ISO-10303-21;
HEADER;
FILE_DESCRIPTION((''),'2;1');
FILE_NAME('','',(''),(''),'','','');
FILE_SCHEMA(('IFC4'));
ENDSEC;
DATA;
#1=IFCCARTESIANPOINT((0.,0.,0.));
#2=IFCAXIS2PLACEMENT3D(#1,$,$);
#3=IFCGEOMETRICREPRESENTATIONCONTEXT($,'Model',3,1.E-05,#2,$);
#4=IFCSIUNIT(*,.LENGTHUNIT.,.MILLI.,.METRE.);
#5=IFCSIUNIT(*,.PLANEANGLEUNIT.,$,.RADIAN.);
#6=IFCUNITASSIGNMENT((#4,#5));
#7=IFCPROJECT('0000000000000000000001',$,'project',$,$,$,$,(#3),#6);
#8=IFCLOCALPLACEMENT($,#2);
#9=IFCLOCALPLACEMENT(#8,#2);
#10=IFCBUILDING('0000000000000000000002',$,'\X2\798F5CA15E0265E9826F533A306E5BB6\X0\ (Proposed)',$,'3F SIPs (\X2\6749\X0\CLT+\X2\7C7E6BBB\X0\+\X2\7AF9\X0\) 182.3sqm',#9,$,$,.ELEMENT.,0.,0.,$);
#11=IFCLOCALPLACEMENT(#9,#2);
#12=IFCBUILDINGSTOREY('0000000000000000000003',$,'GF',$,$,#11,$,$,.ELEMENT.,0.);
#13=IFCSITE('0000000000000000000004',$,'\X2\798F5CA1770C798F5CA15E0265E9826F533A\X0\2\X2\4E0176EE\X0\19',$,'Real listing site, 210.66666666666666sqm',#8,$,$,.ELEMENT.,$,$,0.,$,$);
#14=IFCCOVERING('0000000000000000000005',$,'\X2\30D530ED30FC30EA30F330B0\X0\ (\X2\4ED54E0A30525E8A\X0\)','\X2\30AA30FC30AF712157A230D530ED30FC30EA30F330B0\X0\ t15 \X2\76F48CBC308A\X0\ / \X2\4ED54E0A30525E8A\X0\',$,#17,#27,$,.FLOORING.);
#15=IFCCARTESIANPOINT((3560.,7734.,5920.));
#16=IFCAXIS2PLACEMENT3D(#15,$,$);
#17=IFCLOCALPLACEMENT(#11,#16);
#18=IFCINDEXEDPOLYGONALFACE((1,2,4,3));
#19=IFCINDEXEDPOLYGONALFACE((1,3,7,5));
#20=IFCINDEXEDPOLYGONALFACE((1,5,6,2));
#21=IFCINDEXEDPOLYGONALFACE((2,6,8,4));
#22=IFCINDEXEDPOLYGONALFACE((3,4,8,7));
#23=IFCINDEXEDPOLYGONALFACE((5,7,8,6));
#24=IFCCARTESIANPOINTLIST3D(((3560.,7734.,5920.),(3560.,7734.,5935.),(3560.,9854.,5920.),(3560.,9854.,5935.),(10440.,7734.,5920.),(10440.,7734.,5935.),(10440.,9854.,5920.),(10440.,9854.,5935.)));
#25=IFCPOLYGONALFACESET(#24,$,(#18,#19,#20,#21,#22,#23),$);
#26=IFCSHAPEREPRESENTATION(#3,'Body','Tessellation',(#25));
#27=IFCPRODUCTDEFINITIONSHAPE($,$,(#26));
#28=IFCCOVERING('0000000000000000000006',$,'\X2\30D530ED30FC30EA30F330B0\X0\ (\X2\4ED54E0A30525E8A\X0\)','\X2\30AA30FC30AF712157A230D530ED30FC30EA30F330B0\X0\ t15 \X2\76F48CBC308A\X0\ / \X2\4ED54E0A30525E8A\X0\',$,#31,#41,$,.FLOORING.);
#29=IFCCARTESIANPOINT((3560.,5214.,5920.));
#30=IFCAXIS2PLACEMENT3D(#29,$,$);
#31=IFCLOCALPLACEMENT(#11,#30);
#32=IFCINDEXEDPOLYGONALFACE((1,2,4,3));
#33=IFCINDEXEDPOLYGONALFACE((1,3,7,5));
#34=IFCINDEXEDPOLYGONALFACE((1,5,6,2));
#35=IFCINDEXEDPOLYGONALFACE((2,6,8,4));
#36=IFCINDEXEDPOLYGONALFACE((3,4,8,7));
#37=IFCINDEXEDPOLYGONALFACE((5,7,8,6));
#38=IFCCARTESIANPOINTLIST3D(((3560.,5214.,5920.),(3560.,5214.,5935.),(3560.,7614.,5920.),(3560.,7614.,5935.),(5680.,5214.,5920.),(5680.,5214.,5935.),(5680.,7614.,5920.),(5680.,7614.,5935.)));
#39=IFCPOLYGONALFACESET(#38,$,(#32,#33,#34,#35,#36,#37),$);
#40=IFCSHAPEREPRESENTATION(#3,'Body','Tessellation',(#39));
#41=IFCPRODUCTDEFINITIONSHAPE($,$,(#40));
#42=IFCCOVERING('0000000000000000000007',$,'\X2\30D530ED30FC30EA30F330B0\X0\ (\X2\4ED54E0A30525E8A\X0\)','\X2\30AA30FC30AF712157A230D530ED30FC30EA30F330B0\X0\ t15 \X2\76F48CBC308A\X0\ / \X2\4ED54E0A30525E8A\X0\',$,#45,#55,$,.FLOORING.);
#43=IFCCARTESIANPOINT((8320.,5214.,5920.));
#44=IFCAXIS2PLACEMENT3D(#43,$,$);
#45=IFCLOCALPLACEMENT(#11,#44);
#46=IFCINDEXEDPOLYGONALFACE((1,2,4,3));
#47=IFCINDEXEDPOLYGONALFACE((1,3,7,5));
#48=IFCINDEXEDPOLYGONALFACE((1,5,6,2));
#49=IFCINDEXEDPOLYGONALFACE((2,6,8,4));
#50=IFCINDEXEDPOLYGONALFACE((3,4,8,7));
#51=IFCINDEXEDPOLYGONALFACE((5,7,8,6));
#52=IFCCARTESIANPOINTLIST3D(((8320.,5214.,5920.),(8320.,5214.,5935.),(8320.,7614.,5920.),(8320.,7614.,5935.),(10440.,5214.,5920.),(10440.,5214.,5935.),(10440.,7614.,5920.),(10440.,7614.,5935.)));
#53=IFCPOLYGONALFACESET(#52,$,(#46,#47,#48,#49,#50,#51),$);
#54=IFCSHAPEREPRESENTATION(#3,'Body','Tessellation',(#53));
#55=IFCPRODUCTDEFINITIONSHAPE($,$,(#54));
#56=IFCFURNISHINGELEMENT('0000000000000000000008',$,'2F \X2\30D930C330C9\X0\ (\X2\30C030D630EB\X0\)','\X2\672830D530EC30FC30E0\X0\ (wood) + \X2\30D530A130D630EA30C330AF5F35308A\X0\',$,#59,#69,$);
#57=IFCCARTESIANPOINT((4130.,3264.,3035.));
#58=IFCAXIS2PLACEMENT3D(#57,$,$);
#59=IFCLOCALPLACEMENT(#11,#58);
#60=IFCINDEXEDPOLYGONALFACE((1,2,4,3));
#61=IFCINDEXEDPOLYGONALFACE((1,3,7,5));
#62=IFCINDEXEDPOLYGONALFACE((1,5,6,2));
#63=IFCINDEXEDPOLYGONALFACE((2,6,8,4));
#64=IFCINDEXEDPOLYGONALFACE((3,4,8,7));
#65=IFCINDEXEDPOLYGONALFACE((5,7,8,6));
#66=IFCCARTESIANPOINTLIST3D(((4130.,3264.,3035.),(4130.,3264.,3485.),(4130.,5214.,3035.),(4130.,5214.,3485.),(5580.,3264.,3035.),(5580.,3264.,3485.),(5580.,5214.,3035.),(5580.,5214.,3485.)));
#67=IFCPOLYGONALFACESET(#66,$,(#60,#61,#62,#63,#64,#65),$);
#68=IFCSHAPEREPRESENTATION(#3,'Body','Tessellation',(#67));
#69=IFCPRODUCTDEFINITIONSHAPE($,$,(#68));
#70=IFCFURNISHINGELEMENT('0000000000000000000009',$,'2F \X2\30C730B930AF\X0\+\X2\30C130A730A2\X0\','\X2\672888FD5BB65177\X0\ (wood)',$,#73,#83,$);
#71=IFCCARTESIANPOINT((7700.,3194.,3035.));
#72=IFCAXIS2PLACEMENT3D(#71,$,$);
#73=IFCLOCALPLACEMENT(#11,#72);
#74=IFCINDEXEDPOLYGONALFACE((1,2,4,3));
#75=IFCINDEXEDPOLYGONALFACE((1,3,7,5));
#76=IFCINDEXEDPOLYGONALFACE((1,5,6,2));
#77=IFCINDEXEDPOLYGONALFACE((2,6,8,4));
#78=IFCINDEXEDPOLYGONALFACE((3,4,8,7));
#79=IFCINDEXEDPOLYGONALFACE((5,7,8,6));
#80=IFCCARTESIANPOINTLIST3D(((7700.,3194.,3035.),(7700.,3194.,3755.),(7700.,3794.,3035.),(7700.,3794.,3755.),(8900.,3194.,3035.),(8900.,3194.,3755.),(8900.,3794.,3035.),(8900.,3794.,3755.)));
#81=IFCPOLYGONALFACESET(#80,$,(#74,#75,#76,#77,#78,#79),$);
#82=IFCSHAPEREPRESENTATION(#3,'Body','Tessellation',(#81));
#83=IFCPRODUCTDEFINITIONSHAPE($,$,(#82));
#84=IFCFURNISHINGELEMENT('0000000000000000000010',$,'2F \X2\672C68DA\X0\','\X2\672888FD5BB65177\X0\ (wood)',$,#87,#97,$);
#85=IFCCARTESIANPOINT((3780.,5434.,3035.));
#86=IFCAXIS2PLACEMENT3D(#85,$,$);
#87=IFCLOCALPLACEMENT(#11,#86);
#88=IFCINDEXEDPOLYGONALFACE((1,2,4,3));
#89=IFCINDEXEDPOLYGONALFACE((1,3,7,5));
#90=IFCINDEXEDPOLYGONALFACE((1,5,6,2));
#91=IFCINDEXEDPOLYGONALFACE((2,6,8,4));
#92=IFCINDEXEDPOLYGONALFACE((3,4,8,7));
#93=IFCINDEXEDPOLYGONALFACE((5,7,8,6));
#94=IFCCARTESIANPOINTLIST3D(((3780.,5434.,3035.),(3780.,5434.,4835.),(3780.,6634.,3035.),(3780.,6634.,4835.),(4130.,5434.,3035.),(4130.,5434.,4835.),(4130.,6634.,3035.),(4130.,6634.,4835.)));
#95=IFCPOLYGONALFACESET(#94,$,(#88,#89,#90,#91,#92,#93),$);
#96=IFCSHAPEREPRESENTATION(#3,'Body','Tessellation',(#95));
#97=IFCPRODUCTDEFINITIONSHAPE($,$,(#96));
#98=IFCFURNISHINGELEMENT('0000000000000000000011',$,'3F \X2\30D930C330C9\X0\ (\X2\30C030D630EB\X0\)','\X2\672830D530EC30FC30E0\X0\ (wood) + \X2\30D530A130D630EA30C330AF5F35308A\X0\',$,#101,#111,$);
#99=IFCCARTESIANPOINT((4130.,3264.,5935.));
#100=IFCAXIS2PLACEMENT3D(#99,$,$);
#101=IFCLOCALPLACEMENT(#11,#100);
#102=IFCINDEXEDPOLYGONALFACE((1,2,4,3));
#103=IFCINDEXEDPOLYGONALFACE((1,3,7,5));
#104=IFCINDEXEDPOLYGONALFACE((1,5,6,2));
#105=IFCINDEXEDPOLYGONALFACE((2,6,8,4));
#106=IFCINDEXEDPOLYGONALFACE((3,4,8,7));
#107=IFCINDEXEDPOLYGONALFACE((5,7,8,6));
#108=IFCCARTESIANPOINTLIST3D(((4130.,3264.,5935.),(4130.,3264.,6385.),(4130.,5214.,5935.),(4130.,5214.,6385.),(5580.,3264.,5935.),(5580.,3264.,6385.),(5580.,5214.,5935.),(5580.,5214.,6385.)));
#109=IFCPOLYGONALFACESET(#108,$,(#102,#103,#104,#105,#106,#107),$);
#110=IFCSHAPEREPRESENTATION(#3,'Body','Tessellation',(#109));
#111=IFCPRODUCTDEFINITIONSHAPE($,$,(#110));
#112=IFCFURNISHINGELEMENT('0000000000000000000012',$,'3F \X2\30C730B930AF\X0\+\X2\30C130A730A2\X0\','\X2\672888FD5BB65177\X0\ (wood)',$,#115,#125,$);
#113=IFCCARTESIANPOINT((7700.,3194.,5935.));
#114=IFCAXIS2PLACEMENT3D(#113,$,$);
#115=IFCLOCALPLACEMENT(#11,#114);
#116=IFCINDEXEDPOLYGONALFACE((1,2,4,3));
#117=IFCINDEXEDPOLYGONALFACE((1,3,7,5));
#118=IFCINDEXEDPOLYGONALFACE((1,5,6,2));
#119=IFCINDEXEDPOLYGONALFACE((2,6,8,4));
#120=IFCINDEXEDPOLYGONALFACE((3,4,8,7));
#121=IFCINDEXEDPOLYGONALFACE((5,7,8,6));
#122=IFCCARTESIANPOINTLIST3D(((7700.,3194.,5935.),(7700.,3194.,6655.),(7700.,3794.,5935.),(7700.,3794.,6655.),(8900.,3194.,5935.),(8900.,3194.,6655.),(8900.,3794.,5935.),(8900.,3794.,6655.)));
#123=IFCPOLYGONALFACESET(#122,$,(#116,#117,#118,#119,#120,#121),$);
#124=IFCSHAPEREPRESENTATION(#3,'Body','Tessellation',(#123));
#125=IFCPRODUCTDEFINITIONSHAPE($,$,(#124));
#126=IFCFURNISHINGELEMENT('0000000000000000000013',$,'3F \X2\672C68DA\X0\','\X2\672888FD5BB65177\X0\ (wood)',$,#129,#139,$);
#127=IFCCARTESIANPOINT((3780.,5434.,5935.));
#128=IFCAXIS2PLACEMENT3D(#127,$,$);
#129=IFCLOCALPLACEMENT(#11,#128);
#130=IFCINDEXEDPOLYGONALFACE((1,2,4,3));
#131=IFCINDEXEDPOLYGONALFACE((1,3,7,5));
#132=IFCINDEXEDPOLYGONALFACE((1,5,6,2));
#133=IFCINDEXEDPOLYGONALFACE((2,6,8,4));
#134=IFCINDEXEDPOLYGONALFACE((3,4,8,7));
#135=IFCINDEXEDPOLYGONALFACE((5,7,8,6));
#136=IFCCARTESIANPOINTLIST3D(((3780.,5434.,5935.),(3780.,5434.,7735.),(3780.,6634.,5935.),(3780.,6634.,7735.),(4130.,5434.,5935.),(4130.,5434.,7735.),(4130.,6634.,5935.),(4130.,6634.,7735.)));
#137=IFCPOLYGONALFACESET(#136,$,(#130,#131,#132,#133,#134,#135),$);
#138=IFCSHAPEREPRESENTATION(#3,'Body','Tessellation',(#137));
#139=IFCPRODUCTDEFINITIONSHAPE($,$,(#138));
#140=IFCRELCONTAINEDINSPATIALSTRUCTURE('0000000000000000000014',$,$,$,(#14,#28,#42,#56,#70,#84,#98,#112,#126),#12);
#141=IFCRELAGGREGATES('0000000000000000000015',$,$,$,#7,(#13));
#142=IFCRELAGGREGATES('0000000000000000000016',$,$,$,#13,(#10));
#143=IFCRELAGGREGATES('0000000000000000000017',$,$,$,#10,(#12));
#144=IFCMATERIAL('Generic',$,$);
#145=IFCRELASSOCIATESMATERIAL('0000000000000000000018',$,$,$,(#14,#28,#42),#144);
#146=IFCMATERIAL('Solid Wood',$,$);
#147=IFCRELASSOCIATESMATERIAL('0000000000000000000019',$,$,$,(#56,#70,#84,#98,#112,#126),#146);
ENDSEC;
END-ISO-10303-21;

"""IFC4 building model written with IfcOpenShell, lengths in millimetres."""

from ifc_helpers import new_model, si_unit, frame, frame_2d, origin, place, context, project, spatial, rectangle, extrude, material, element, save


model = new_model("IFC4")

# Units and contexts
model_context = context("Model", 3, precision=1e-05, world=origin())
ifc_project = project(units=[si_unit("LENGTHUNIT", "METRE", prefix="MILLI"), si_unit("PLANEANGLEUNIT", "RADIAN")], contexts=[model_context])

# Site, building, storey
site_placement = place(None, origin())
site = spatial("IfcSite", under=ifc_project, at=site_placement, Name="福岡県福岡市早良区2丁目19", ObjectType="Real listing site, 210.66666666666666sqm", CompositionType="ELEMENT", RefElevation=0.0)
building_placement = place(site_placement, origin())
building = spatial("IfcBuilding", under=site, at=building_placement, Name="福岡市早良区の家 (Proposed)", ObjectType="3F SIPs (杉CLT+籾殻+竹) 182.3sqm", CompositionType="ELEMENT", ElevationOfRefHeight=0.0, ElevationOfTerrain=0.0)
storey_placement = place(building_placement, origin())
storey = spatial("IfcBuildingStorey", under=building, at=storey_placement, Name="GF", CompositionType="ELEMENT", Elevation=0.0)

# Shared definitions
ifc_material_1 = material(Name="Solid Wood")

# Shared definitions
ifc_material_2 = material(Name="Generic")

# Coverings
covering_1_placement = place(storey_placement, frame((3560.0, 7734.0, 5920.0)))
element("IfcCovering", 1, at=covering_1_placement, inside=storey, material=ifc_material_2, Name="フローリング (仕上げ床)", Description="オーク無垢フローリング t15 直貼り / 仕上げ床", PredefinedType="FLOORING", context=model_context, shape_type="SweptSolid", body=[
    extrude(rectangle(XDim=6880.0, YDim=2120.0, at=frame_2d((3440.0, 1060.0))), frame((3560.0, 7734.0, 5920.0)), (0.0, 0.0, 1.0), 15.0),
])
covering_2_placement = place(storey_placement, frame((3560.0, 5214.0, 5920.0)))
element("IfcCovering", 2, at=covering_2_placement, inside=storey, material=ifc_material_2, Name="フローリング (仕上げ床)", Description="オーク無垢フローリング t15 直貼り / 仕上げ床", PredefinedType="FLOORING", context=model_context, shape_type="SweptSolid", body=[
    extrude(rectangle(XDim=2120.0, YDim=2400.0, at=frame_2d((1060.0, 1200.0))), frame((3560.0, 5214.0, 5920.0)), (0.0, 0.0, 1.0), 15.0),
])
covering_3_placement = place(storey_placement, frame((8320.0, 5214.0, 5920.0)))
element("IfcCovering", 3, at=covering_3_placement, inside=storey, material=ifc_material_2, Name="フローリング (仕上げ床)", Description="オーク無垢フローリング t15 直貼り / 仕上げ床", PredefinedType="FLOORING", context=model_context, shape_type="SweptSolid", body=[
    extrude(rectangle(XDim=2120.0, YDim=2400.0, at=frame_2d((1060.0, 1200.0))), frame((8320.0, 5214.0, 5920.0)), (0.0, 0.0, 1.0), 15.0),
])

# Furnishing elements
furnishing_1_placement = place(storey_placement, frame((4130.0, 3264.0, 3035.0)))
element("IfcFurnishingElement", 4, at=furnishing_1_placement, inside=storey, material=ifc_material_1, Name="2F ベッド (ダブル)", Description="木フレーム (wood) + ファブリック張り", context=model_context, shape_type="SweptSolid", body=[
    extrude(rectangle(XDim=1450.0, YDim=1950.0, at=frame_2d((725.0, 975.0))), frame((4130.0, 3264.0, 3035.0)), (0.0, 0.0, 1.0), 450.0),
])
furnishing_2_placement = place(storey_placement, frame((7700.0, 3194.0, 3035.0)))
element("IfcFurnishingElement", 5, at=furnishing_2_placement, inside=storey, material=ifc_material_1, Name="2F デスク+チェア", Description="木製家具 (wood)", context=model_context, shape_type="SweptSolid", body=[
    extrude(rectangle(XDim=1200.0, YDim=600.0, at=frame_2d((600.0, 300.0))), frame((7700.0, 3194.0, 3035.0)), (0.0, 0.0, 1.0), 720.0),
])
furnishing_3_placement = place(storey_placement, frame((3780.0, 5434.0, 3035.0)))
element("IfcFurnishingElement", 6, at=furnishing_3_placement, inside=storey, material=ifc_material_1, Name="2F 本棚", Description="木製家具 (wood)", context=model_context, shape_type="SweptSolid", body=[
    extrude(rectangle(XDim=350.0, YDim=1200.0, at=frame_2d((175.0, 600.0))), frame((3780.0, 5434.0, 3035.0)), (0.0, 0.0, 1.0), 1800.0),
])
furnishing_4_placement = place(storey_placement, frame((4130.0, 3264.0, 5935.0)))
element("IfcFurnishingElement", 7, at=furnishing_4_placement, inside=storey, material=ifc_material_1, Name="3F ベッド (ダブル)", Description="木フレーム (wood) + ファブリック張り", context=model_context, shape_type="SweptSolid", body=[
    extrude(rectangle(XDim=1450.0, YDim=1950.0, at=frame_2d((725.0, 975.0))), frame((4130.0, 3264.0, 5935.0)), (0.0, 0.0, 1.0), 450.0),
])
furnishing_5_placement = place(storey_placement, frame((7700.0, 3194.0, 5935.0)))
element("IfcFurnishingElement", 8, at=furnishing_5_placement, inside=storey, material=ifc_material_1, Name="3F デスク+チェア", Description="木製家具 (wood)", context=model_context, shape_type="SweptSolid", body=[
    extrude(rectangle(XDim=1200.0, YDim=600.0, at=frame_2d((600.0, 300.0))), frame((7700.0, 3194.0, 5935.0)), (0.0, 0.0, 1.0), 720.0),
])
furnishing_6_placement = place(storey_placement, frame((3780.0, 5434.0, 5935.0)))
element("IfcFurnishingElement", 9, at=furnishing_6_placement, inside=storey, material=ifc_material_1, Name="3F 本棚", Description="木製家具 (wood)", context=model_context, shape_type="SweptSolid", body=[
    extrude(rectangle(XDim=350.0, YDim=1200.0, at=frame_2d((175.0, 600.0))), frame((3780.0, 5434.0, 5935.0)), (0.0, 0.0, 1.0), 1800.0),
])

save(model, "model.ifc")
